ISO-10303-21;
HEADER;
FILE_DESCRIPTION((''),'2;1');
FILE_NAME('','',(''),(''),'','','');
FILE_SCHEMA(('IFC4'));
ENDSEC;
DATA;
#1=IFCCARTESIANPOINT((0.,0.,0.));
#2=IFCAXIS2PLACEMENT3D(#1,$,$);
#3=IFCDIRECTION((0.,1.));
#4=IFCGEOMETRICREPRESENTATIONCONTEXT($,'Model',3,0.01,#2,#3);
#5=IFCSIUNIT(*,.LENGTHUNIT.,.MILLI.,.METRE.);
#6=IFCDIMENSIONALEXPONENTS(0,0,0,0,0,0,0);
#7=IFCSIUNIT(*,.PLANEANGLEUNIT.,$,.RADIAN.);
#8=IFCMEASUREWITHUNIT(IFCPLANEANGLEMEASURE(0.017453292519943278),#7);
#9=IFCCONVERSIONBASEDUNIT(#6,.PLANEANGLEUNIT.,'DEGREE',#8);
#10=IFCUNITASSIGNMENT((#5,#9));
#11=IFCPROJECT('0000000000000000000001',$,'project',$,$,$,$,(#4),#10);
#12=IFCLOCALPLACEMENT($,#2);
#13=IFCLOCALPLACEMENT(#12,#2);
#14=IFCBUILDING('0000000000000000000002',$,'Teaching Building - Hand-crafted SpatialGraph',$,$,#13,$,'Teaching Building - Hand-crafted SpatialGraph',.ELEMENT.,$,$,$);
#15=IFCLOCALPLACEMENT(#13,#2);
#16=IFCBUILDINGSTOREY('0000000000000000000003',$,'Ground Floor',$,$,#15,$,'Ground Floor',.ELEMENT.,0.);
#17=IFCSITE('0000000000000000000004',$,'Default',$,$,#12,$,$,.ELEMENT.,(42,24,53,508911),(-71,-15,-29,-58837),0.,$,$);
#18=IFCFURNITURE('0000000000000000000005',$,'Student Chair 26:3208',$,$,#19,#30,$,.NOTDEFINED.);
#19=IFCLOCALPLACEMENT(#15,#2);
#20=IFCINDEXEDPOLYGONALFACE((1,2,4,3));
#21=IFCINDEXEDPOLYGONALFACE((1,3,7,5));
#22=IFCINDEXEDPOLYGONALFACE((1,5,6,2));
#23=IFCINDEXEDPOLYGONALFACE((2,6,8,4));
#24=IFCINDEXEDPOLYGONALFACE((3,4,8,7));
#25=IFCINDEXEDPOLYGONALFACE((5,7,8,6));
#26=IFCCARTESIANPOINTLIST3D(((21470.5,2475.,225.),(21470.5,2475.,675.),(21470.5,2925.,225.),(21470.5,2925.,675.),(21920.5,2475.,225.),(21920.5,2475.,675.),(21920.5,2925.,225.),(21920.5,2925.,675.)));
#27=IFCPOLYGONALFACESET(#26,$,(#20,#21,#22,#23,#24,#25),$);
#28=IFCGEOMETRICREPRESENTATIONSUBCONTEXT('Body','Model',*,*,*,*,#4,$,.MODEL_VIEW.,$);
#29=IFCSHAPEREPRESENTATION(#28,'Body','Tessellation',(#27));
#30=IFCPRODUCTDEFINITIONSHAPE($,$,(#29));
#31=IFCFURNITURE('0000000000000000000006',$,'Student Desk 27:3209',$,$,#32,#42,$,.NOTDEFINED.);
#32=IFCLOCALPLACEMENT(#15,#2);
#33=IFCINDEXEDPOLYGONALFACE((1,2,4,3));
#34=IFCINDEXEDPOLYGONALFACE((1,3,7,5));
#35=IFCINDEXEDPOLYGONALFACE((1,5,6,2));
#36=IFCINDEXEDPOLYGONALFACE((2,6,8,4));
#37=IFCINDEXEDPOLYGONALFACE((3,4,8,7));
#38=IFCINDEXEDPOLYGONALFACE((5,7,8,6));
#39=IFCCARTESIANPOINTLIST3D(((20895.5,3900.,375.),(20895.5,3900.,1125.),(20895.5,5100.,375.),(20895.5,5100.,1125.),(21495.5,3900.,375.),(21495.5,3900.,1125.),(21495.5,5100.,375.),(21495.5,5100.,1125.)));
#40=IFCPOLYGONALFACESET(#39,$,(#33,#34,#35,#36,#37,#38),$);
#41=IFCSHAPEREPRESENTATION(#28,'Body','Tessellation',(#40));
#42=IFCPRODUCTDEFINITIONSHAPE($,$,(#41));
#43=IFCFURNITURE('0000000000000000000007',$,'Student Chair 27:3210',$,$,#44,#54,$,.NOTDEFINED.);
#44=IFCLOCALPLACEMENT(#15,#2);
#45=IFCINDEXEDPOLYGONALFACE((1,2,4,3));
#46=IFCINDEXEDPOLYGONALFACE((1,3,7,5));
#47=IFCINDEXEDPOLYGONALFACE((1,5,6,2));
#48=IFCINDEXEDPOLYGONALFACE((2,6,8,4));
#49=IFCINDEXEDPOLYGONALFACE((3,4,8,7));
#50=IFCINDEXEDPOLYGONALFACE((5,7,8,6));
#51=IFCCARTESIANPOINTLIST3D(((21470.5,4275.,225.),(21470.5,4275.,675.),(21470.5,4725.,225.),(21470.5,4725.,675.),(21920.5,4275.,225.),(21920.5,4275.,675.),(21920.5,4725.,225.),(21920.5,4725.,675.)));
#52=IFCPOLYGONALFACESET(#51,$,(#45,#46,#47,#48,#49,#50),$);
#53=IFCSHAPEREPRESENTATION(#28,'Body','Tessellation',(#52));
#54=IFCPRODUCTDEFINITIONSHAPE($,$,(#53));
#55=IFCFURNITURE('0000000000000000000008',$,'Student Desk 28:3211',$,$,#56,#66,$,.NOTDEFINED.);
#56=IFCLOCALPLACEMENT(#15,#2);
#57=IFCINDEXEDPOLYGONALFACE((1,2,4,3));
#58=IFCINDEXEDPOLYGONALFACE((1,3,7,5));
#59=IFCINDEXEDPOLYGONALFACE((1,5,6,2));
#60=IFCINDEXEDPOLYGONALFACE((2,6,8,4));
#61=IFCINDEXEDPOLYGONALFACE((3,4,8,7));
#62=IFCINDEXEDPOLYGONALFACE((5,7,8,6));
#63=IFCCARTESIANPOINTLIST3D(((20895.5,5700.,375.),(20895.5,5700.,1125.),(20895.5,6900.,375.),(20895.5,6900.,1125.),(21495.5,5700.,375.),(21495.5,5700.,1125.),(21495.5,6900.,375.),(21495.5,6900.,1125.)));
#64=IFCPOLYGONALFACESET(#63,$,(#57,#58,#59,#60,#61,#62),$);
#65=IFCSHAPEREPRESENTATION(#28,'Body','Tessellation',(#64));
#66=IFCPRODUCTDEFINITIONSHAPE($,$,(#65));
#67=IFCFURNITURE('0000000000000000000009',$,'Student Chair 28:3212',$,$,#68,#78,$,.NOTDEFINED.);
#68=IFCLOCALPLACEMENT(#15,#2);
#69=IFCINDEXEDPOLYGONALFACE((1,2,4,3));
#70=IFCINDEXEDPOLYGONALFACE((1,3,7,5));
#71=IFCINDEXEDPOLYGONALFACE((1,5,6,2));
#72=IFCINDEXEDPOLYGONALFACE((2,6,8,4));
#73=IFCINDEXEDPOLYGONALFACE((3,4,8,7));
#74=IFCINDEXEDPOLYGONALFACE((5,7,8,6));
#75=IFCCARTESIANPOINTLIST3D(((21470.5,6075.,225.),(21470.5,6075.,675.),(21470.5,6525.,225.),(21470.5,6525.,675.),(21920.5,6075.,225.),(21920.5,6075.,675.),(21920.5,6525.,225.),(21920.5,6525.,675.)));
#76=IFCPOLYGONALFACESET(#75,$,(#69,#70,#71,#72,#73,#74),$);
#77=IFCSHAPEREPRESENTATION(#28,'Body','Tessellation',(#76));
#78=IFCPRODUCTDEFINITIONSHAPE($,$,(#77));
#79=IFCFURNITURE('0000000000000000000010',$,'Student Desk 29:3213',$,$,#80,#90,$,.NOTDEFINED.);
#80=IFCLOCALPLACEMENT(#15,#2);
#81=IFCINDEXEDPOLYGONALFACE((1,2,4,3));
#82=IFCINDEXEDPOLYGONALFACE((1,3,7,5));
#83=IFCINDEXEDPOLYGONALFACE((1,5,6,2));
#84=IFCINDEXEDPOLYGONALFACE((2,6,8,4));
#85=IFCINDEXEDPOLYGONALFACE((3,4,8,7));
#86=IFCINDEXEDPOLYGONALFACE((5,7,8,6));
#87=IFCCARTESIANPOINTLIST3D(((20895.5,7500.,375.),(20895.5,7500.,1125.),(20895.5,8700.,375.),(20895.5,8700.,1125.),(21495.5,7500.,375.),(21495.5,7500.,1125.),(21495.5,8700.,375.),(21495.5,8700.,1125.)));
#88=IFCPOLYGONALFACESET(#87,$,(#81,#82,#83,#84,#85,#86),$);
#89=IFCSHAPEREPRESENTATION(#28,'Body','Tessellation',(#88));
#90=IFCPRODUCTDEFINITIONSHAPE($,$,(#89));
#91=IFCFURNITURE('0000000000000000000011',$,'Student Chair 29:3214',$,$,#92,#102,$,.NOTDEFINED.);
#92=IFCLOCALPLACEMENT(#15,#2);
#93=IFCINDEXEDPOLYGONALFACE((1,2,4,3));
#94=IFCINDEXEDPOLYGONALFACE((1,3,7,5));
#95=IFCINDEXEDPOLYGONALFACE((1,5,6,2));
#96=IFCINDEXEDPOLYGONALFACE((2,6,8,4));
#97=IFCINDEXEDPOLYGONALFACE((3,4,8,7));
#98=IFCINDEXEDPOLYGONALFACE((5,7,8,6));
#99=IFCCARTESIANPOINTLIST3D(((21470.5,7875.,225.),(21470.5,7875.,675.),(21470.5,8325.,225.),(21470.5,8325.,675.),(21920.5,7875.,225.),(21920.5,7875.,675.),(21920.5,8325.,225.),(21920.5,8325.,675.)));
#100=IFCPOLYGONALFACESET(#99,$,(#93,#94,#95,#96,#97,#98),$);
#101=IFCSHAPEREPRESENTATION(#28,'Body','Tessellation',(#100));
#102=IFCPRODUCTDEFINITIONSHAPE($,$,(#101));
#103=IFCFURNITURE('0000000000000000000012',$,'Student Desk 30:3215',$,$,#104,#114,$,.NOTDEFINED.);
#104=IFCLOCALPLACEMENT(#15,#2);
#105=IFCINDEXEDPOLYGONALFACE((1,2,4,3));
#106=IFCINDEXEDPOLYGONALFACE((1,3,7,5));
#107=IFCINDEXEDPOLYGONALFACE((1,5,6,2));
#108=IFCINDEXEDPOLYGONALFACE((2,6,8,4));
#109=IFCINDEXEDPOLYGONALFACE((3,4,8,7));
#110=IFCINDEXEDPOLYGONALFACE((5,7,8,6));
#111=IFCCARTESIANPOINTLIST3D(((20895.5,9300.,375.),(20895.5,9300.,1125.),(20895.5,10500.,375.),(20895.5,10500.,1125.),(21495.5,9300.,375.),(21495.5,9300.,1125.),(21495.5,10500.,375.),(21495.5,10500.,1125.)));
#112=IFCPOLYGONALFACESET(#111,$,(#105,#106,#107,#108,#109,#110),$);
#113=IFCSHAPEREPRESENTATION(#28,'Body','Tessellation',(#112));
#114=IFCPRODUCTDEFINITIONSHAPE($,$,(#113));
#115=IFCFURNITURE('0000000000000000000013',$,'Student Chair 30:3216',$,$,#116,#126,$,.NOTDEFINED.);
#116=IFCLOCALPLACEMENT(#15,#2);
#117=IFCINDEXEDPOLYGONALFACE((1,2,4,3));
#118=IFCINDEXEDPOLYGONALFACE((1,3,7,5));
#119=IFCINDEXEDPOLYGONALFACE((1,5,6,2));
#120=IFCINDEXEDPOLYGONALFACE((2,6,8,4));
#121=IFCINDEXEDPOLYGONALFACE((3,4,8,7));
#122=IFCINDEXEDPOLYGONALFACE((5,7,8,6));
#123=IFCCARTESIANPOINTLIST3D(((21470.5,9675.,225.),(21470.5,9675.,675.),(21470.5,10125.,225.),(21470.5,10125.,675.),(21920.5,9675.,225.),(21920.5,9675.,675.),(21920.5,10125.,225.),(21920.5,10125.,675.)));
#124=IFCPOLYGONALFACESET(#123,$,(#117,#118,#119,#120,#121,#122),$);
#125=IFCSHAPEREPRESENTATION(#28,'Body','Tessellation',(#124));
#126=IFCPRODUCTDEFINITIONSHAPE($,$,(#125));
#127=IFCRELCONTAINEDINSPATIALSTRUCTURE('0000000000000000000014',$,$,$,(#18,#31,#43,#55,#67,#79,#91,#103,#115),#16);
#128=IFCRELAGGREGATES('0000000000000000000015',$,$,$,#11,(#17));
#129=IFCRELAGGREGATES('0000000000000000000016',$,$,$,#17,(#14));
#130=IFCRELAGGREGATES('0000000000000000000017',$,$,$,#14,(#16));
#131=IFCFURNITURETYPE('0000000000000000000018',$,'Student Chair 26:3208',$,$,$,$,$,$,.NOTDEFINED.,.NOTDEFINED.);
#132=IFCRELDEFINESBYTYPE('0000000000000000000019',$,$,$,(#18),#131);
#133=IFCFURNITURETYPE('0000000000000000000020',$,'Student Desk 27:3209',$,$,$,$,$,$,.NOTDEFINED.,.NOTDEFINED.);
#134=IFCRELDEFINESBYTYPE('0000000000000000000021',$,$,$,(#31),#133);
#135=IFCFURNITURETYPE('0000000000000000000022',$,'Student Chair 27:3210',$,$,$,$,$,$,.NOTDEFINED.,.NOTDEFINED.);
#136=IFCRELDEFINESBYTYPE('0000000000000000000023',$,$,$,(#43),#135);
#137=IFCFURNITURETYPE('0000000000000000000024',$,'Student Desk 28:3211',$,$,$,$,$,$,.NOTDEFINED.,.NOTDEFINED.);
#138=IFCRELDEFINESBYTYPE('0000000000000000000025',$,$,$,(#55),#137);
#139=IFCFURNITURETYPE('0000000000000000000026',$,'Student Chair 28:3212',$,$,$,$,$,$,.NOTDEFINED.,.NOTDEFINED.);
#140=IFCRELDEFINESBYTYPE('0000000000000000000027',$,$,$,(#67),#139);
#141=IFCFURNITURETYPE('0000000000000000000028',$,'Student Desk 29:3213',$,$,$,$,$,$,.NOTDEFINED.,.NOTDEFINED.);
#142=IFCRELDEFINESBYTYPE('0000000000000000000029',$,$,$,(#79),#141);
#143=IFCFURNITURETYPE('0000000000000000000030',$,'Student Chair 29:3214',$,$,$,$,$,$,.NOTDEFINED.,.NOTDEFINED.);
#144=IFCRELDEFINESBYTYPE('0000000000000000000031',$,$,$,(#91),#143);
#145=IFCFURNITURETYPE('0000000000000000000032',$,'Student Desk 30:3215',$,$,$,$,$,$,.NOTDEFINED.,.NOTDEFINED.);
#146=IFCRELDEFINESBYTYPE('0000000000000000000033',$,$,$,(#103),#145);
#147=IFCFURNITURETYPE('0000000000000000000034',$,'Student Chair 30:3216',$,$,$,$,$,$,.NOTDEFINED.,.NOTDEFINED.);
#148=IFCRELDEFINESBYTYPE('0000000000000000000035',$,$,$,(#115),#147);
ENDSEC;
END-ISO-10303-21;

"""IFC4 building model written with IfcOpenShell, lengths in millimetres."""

from ifc_helpers import new_model, entity, si_unit, converted_unit, direction, frame, frame_2d, origin, origin_2d_with_axis, place, context, subcontext, project, spatial, rectangle, extrude, type_object, element, save


model = new_model("IFC4")

# Units and contexts
model_context = context("Model", 3, precision=0.01, world=origin(), true_north=direction((0.0, 1.0)))
body_context = subcontext(model_context, "Body", "Model", "MODEL_VIEW")
ifc_project = project(units=[si_unit("LENGTHUNIT", "METRE", prefix="MILLI"), converted_unit("PLANEANGLEUNIT", "DEGREE", entity("IfcPlaneAngleMeasure", 0.017453292519943278), si_unit("PLANEANGLEUNIT", "RADIAN"), dimensions=[0, 0, 0, 0, 0, 0, 0])], contexts=[model_context])

# Site, building, storey
site_placement = place(None, origin())
site = spatial("IfcSite", under=ifc_project, at=site_placement, Name="Default", CompositionType="ELEMENT", RefLatitude=(42, 24, 53, 508911), RefLongitude=(-71, -15, -29, -58837), RefElevation=0.0)
building_placement = place(site_placement, origin())
building = spatial("IfcBuilding", under=site, at=building_placement, Name="Teaching Building - Hand-crafted SpatialGraph", LongName="Teaching Building - Hand-crafted SpatialGraph", CompositionType="ELEMENT")
storey_placement = place(building_placement, origin())
storey = spatial("IfcBuildingStorey", under=building, at=storey_placement, Name="Ground Floor", LongName="Ground Floor", CompositionType="ELEMENT", Elevation=0.0)

# Furniture
furniture_type_1 = type_object("IfcFurnitureType", Name="Student Chair 26:3208", PredefinedType="NOTDEFINED")
furniture_1_placement = place(storey_placement, origin())
element("IfcFurniture", 1, at=furniture_1_placement, inside=storey, type_object=furniture_type_1, Name="Student Chair 26:3208", PredefinedType="NOTDEFINED", context=body_context, shape_type="SweptSolid", body=[
    extrude(rectangle(XDim=450.0, YDim=450.0, at=origin_2d_with_axis()), frame((21695.5, 2700.0, 225.0)), (0.0, 0.0, 1.0), 450.0),
])
furniture_type_2 = type_object("IfcFurnitureType", Name="Student Desk 27:3209", PredefinedType="NOTDEFINED")
furniture_2_placement = place(storey_placement, origin())
element("IfcFurniture", 2, at=furniture_2_placement, inside=storey, type_object=furniture_type_2, Name="Student Desk 27:3209", PredefinedType="NOTDEFINED", context=body_context, shape_type="SweptSolid", body=[
    extrude(rectangle(XDim=1200.0, YDim=600.0, at=frame_2d((0.0, 0.0), x_axis=(1.0, 0.0))), frame((21195.5, 4500.0, 375.0), z_axis=(0.0, 0.0, 1.0), x_axis=(0.0, 1.0, 0.0)), (0.0, 0.0, 1.0), 750.0),
])
furniture_type_3 = type_object("IfcFurnitureType", Name="Student Chair 27:3210", PredefinedType="NOTDEFINED")
furniture_3_placement = place(storey_placement, origin())
element("IfcFurniture", 3, at=furniture_3_placement, inside=storey, type_object=furniture_type_3, Name="Student Chair 27:3210", PredefinedType="NOTDEFINED", context=body_context, shape_type="SweptSolid", body=[
    extrude(rectangle(XDim=450.0, YDim=450.0, at=origin_2d_with_axis()), frame((21695.5, 4500.0, 225.0)), (0.0, 0.0, 1.0), 450.0),
])
furniture_type_4 = type_object("IfcFurnitureType", Name="Student Desk 28:3211", PredefinedType="NOTDEFINED")
furniture_4_placement = place(storey_placement, origin())
element("IfcFurniture", 4, at=furniture_4_placement, inside=storey, type_object=furniture_type_4, Name="Student Desk 28:3211", PredefinedType="NOTDEFINED", context=body_context, shape_type="SweptSolid", body=[
    extrude(rectangle(XDim=1200.0, YDim=600.0, at=origin_2d_with_axis()), frame((21195.5, 6300.0, 375.0), z_axis=(0.0, 0.0, 1.0), x_axis=(0.0, 1.0, 0.0)), (0.0, 0.0, 1.0), 750.0),
])
furniture_type_5 = type_object("IfcFurnitureType", Name="Student Chair 28:3212", PredefinedType="NOTDEFINED")
furniture_5_placement = place(storey_placement, origin())
element("IfcFurniture", 5, at=furniture_5_placement, inside=storey, type_object=furniture_type_5, Name="Student Chair 28:3212", PredefinedType="NOTDEFINED", context=body_context, shape_type="SweptSolid", body=[
    extrude(rectangle(XDim=450.0, YDim=450.0, at=origin_2d_with_axis()), frame((21695.5, 6300.0, 225.0)), (0.0, 0.0, 1.0), 450.0),
])
furniture_type_6 = type_object("IfcFurnitureType", Name="Student Desk 29:3213", PredefinedType="NOTDEFINED")
furniture_6_placement = place(storey_placement, origin())
element("IfcFurniture", 6, at=furniture_6_placement, inside=storey, type_object=furniture_type_6, Name="Student Desk 29:3213", PredefinedType="NOTDEFINED", context=body_context, shape_type="SweptSolid", body=[
    extrude(rectangle(XDim=1200.0, YDim=600.0, at=origin_2d_with_axis()), frame((21195.5, 8100.0, 375.0), z_axis=(0.0, 0.0, 1.0), x_axis=(0.0, 1.0, 0.0)), (0.0, 0.0, 1.0), 750.0),
])
furniture_type_7 = type_object("IfcFurnitureType", Name="Student Chair 29:3214", PredefinedType="NOTDEFINED")
furniture_7_placement = place(storey_placement, origin())
element("IfcFurniture", 7, at=furniture_7_placement, inside=storey, type_object=furniture_type_7, Name="Student Chair 29:3214", PredefinedType="NOTDEFINED", context=body_context, shape_type="SweptSolid", body=[
    extrude(rectangle(XDim=450.0, YDim=450.0, at=origin_2d_with_axis()), frame((21695.5, 8100.0, 225.0)), (0.0, 0.0, 1.0), 450.0),
])
furniture_type_8 = type_object("IfcFurnitureType", Name="Student Desk 30:3215", PredefinedType="NOTDEFINED")
furniture_8_placement = place(storey_placement, origin())
element("IfcFurniture", 8, at=furniture_8_placement, inside=storey, type_object=furniture_type_8, Name="Student Desk 30:3215", PredefinedType="NOTDEFINED", context=body_context, shape_type="SweptSolid", body=[
    extrude(rectangle(XDim=1200.0, YDim=600.0, at=origin_2d_with_axis()), frame((21195.5, 9900.0, 375.0), z_axis=(0.0, 0.0, 1.0), x_axis=(0.0, 1.0, 0.0)), (0.0, 0.0, 1.0), 750.0),
])
furniture_type_9 = type_object("IfcFurnitureType", Name="Student Chair 30:3216", PredefinedType="NOTDEFINED")
furniture_9_placement = place(storey_placement, origin())
element("IfcFurniture", 9, at=furniture_9_placement, inside=storey, type_object=furniture_type_9, Name="Student Chair 30:3216", PredefinedType="NOTDEFINED", context=body_context, shape_type="SweptSolid", body=[
    extrude(rectangle(XDim=450.0, YDim=450.0, at=frame_2d((0.0, 0.0), x_axis=(1.0, 0.0))), frame((21695.5, 9900.0, 225.0)), (0.0, 0.0, 1.0), 450.0),
])

save(model, "model.ifc")
